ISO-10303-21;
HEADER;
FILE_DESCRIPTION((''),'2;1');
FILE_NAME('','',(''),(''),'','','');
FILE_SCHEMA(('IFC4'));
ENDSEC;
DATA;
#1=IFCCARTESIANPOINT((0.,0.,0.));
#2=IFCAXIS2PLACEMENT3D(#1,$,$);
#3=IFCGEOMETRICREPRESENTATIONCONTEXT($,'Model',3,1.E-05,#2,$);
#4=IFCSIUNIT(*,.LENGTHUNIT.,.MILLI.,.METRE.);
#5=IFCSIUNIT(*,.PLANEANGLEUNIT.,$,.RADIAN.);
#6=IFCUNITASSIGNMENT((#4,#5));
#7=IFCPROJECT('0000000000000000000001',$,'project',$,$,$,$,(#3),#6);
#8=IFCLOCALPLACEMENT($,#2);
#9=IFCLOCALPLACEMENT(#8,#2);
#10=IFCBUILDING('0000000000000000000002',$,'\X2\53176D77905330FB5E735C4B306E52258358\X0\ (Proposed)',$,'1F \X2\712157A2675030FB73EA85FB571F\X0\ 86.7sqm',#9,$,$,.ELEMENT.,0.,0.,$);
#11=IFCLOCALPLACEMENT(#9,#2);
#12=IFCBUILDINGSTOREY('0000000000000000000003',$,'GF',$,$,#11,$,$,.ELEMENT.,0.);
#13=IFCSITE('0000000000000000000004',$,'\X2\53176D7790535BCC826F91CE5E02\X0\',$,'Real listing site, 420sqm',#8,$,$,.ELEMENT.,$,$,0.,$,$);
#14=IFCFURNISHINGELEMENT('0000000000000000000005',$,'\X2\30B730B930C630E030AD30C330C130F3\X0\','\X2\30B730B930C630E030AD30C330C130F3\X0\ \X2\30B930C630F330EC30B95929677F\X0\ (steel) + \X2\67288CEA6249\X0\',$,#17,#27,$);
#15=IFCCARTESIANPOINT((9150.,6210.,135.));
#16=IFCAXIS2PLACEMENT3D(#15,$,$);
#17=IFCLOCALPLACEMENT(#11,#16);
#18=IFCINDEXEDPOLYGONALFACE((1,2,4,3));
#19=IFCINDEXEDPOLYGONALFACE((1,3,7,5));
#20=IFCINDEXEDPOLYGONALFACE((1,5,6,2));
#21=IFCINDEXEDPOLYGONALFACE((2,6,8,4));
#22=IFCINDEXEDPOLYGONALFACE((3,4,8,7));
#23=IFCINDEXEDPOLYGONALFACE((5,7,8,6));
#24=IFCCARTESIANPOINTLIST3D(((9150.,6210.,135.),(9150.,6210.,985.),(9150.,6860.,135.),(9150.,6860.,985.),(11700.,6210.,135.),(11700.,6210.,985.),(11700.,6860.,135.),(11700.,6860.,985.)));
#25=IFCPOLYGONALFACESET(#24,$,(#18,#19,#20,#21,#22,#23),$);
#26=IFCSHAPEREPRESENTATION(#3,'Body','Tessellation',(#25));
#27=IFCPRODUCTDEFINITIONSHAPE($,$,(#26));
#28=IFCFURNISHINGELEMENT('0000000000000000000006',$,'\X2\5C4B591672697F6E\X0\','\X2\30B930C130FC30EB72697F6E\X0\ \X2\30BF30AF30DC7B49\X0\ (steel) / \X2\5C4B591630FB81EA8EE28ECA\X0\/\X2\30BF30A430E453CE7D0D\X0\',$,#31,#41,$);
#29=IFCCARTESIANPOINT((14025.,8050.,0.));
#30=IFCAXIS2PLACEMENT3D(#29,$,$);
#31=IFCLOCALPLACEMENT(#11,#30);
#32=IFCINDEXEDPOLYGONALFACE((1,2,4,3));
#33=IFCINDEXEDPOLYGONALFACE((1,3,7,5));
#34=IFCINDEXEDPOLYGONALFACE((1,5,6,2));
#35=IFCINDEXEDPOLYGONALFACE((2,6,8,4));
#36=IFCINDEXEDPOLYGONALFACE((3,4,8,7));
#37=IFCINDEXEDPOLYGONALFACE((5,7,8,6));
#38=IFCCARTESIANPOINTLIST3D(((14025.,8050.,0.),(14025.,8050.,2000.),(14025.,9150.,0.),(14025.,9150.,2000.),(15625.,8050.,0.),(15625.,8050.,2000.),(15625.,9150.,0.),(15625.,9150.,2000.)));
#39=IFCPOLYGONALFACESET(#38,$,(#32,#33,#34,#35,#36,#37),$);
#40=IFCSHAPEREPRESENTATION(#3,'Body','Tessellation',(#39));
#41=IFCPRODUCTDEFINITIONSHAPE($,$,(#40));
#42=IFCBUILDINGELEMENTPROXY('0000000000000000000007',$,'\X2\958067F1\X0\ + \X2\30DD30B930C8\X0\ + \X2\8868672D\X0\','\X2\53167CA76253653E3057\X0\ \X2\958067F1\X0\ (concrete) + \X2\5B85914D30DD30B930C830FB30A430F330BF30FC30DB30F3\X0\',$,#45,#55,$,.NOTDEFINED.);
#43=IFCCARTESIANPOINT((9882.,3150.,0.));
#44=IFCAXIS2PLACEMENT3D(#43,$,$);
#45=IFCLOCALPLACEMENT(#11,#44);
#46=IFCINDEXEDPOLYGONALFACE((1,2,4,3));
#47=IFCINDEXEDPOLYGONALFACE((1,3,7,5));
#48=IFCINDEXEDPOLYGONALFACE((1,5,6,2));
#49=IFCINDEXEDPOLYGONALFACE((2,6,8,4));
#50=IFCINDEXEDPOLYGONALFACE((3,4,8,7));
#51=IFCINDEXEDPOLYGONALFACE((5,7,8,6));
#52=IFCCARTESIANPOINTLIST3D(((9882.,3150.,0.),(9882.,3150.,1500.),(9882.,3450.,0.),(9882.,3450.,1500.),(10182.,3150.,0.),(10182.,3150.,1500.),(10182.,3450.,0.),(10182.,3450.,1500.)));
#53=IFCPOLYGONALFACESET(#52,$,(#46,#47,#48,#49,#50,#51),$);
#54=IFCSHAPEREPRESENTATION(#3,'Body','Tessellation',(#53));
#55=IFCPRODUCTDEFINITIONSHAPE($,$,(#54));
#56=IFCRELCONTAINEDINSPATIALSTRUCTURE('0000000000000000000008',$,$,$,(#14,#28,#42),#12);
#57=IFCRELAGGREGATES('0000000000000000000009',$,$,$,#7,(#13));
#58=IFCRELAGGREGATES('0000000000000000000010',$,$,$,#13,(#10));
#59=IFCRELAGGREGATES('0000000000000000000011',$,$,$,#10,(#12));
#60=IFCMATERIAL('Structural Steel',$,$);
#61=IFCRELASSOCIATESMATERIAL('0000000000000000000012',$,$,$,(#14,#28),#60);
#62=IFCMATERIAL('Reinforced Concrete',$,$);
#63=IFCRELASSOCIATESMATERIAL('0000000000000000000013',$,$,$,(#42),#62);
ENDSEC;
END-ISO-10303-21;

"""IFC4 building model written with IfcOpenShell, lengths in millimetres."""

from ifc_helpers import new_model, si_unit, frame, frame_2d, origin, place, context, project, spatial, rectangle, extrude, material, element, save


model = new_model("IFC4")

# Units and contexts
model_context = context("Model", 3, precision=1e-05, world=origin())
ifc_project = project(units=[si_unit("LENGTHUNIT", "METRE", prefix="MILLI"), si_unit("PLANEANGLEUNIT", "RADIAN")], contexts=[model_context])

# Site, building, storey
site_placement = place(None, origin())
site = spatial("IfcSite", under=ifc_project, at=site_placement, Name="北海道富良野市", ObjectType="Real listing site, 420sqm", CompositionType="ELEMENT", RefElevation=0.0)
building_placement = place(site_placement, origin())
building = spatial("IfcBuilding", under=site, at=building_placement, Name="北海道・平屋の別荘 (Proposed)", ObjectType="1F 無垢材・珪藻土 86.7sqm", CompositionType="ELEMENT", ElevationOfRefHeight=0.0, ElevationOfTerrain=0.0)
storey_placement = place(building_placement, origin())
storey = spatial("IfcBuildingStorey", under=building, at=storey_placement, Name="GF", CompositionType="ELEMENT", Elevation=0.0)

# Shared definitions
ifc_material_1 = material(Name="Reinforced Concrete")

# Shared definitions
ifc_material_2 = material(Name="Structural Steel")

# Furnishing elements
furnishing_1_placement = place(storey_placement, frame((9150.0, 6210.0, 135.0)))
element("IfcFurnishingElement", 1, at=furnishing_1_placement, inside=storey, material=ifc_material_2, Name="システムキッチン", Description="システムキッチン ステンレス天板 (steel) + 木質扉", context=model_context, shape_type="SweptSolid", body=[
    extrude(rectangle(XDim=2550.0, YDim=650.0, at=frame_2d((1275.0, 325.0))), frame((9150.0, 6210.0, 135.0)), (0.0, 0.0, 1.0), 850.0),
])
furnishing_2_placement = place(storey_placement, frame((14025.0, 8050.0, 0.0)))
element("IfcFurnishingElement", 2, at=furnishing_2_placement, inside=storey, material=ifc_material_2, Name="屋外物置", Description="スチール物置 タクボ等 (steel) / 屋外・自転車/タイヤ収納", context=model_context, shape_type="SweptSolid", body=[
    extrude(rectangle(XDim=1600.0, YDim=1100.0, at=frame_2d((800.0, 550.0))), frame((14025.0, 8050.0, 0.0)), (0.0, 0.0, 1.0), 2000.0),
])

# Building element proxy
proxy_placement = place(storey_placement, frame((9882.0, 3150.0, 0.0)))
element("IfcBuildingElementProxy", 3, at=proxy_placement, inside=storey, material=ifc_material_1, Name="門柱 + ポスト + 表札", Description="化粧打放し 門柱 (concrete) + 宅配ポスト・インターホン", PredefinedType="NOTDEFINED", context=model_context, shape_type="SweptSolid", body=[
    extrude(rectangle(XDim=300.0, YDim=300.0, at=frame_2d((150.0, 150.0))), frame((9882.0, 3150.0, 0.0)), (0.0, 0.0, 1.0), 1500.0),
])

save(model, "model.ifc")
